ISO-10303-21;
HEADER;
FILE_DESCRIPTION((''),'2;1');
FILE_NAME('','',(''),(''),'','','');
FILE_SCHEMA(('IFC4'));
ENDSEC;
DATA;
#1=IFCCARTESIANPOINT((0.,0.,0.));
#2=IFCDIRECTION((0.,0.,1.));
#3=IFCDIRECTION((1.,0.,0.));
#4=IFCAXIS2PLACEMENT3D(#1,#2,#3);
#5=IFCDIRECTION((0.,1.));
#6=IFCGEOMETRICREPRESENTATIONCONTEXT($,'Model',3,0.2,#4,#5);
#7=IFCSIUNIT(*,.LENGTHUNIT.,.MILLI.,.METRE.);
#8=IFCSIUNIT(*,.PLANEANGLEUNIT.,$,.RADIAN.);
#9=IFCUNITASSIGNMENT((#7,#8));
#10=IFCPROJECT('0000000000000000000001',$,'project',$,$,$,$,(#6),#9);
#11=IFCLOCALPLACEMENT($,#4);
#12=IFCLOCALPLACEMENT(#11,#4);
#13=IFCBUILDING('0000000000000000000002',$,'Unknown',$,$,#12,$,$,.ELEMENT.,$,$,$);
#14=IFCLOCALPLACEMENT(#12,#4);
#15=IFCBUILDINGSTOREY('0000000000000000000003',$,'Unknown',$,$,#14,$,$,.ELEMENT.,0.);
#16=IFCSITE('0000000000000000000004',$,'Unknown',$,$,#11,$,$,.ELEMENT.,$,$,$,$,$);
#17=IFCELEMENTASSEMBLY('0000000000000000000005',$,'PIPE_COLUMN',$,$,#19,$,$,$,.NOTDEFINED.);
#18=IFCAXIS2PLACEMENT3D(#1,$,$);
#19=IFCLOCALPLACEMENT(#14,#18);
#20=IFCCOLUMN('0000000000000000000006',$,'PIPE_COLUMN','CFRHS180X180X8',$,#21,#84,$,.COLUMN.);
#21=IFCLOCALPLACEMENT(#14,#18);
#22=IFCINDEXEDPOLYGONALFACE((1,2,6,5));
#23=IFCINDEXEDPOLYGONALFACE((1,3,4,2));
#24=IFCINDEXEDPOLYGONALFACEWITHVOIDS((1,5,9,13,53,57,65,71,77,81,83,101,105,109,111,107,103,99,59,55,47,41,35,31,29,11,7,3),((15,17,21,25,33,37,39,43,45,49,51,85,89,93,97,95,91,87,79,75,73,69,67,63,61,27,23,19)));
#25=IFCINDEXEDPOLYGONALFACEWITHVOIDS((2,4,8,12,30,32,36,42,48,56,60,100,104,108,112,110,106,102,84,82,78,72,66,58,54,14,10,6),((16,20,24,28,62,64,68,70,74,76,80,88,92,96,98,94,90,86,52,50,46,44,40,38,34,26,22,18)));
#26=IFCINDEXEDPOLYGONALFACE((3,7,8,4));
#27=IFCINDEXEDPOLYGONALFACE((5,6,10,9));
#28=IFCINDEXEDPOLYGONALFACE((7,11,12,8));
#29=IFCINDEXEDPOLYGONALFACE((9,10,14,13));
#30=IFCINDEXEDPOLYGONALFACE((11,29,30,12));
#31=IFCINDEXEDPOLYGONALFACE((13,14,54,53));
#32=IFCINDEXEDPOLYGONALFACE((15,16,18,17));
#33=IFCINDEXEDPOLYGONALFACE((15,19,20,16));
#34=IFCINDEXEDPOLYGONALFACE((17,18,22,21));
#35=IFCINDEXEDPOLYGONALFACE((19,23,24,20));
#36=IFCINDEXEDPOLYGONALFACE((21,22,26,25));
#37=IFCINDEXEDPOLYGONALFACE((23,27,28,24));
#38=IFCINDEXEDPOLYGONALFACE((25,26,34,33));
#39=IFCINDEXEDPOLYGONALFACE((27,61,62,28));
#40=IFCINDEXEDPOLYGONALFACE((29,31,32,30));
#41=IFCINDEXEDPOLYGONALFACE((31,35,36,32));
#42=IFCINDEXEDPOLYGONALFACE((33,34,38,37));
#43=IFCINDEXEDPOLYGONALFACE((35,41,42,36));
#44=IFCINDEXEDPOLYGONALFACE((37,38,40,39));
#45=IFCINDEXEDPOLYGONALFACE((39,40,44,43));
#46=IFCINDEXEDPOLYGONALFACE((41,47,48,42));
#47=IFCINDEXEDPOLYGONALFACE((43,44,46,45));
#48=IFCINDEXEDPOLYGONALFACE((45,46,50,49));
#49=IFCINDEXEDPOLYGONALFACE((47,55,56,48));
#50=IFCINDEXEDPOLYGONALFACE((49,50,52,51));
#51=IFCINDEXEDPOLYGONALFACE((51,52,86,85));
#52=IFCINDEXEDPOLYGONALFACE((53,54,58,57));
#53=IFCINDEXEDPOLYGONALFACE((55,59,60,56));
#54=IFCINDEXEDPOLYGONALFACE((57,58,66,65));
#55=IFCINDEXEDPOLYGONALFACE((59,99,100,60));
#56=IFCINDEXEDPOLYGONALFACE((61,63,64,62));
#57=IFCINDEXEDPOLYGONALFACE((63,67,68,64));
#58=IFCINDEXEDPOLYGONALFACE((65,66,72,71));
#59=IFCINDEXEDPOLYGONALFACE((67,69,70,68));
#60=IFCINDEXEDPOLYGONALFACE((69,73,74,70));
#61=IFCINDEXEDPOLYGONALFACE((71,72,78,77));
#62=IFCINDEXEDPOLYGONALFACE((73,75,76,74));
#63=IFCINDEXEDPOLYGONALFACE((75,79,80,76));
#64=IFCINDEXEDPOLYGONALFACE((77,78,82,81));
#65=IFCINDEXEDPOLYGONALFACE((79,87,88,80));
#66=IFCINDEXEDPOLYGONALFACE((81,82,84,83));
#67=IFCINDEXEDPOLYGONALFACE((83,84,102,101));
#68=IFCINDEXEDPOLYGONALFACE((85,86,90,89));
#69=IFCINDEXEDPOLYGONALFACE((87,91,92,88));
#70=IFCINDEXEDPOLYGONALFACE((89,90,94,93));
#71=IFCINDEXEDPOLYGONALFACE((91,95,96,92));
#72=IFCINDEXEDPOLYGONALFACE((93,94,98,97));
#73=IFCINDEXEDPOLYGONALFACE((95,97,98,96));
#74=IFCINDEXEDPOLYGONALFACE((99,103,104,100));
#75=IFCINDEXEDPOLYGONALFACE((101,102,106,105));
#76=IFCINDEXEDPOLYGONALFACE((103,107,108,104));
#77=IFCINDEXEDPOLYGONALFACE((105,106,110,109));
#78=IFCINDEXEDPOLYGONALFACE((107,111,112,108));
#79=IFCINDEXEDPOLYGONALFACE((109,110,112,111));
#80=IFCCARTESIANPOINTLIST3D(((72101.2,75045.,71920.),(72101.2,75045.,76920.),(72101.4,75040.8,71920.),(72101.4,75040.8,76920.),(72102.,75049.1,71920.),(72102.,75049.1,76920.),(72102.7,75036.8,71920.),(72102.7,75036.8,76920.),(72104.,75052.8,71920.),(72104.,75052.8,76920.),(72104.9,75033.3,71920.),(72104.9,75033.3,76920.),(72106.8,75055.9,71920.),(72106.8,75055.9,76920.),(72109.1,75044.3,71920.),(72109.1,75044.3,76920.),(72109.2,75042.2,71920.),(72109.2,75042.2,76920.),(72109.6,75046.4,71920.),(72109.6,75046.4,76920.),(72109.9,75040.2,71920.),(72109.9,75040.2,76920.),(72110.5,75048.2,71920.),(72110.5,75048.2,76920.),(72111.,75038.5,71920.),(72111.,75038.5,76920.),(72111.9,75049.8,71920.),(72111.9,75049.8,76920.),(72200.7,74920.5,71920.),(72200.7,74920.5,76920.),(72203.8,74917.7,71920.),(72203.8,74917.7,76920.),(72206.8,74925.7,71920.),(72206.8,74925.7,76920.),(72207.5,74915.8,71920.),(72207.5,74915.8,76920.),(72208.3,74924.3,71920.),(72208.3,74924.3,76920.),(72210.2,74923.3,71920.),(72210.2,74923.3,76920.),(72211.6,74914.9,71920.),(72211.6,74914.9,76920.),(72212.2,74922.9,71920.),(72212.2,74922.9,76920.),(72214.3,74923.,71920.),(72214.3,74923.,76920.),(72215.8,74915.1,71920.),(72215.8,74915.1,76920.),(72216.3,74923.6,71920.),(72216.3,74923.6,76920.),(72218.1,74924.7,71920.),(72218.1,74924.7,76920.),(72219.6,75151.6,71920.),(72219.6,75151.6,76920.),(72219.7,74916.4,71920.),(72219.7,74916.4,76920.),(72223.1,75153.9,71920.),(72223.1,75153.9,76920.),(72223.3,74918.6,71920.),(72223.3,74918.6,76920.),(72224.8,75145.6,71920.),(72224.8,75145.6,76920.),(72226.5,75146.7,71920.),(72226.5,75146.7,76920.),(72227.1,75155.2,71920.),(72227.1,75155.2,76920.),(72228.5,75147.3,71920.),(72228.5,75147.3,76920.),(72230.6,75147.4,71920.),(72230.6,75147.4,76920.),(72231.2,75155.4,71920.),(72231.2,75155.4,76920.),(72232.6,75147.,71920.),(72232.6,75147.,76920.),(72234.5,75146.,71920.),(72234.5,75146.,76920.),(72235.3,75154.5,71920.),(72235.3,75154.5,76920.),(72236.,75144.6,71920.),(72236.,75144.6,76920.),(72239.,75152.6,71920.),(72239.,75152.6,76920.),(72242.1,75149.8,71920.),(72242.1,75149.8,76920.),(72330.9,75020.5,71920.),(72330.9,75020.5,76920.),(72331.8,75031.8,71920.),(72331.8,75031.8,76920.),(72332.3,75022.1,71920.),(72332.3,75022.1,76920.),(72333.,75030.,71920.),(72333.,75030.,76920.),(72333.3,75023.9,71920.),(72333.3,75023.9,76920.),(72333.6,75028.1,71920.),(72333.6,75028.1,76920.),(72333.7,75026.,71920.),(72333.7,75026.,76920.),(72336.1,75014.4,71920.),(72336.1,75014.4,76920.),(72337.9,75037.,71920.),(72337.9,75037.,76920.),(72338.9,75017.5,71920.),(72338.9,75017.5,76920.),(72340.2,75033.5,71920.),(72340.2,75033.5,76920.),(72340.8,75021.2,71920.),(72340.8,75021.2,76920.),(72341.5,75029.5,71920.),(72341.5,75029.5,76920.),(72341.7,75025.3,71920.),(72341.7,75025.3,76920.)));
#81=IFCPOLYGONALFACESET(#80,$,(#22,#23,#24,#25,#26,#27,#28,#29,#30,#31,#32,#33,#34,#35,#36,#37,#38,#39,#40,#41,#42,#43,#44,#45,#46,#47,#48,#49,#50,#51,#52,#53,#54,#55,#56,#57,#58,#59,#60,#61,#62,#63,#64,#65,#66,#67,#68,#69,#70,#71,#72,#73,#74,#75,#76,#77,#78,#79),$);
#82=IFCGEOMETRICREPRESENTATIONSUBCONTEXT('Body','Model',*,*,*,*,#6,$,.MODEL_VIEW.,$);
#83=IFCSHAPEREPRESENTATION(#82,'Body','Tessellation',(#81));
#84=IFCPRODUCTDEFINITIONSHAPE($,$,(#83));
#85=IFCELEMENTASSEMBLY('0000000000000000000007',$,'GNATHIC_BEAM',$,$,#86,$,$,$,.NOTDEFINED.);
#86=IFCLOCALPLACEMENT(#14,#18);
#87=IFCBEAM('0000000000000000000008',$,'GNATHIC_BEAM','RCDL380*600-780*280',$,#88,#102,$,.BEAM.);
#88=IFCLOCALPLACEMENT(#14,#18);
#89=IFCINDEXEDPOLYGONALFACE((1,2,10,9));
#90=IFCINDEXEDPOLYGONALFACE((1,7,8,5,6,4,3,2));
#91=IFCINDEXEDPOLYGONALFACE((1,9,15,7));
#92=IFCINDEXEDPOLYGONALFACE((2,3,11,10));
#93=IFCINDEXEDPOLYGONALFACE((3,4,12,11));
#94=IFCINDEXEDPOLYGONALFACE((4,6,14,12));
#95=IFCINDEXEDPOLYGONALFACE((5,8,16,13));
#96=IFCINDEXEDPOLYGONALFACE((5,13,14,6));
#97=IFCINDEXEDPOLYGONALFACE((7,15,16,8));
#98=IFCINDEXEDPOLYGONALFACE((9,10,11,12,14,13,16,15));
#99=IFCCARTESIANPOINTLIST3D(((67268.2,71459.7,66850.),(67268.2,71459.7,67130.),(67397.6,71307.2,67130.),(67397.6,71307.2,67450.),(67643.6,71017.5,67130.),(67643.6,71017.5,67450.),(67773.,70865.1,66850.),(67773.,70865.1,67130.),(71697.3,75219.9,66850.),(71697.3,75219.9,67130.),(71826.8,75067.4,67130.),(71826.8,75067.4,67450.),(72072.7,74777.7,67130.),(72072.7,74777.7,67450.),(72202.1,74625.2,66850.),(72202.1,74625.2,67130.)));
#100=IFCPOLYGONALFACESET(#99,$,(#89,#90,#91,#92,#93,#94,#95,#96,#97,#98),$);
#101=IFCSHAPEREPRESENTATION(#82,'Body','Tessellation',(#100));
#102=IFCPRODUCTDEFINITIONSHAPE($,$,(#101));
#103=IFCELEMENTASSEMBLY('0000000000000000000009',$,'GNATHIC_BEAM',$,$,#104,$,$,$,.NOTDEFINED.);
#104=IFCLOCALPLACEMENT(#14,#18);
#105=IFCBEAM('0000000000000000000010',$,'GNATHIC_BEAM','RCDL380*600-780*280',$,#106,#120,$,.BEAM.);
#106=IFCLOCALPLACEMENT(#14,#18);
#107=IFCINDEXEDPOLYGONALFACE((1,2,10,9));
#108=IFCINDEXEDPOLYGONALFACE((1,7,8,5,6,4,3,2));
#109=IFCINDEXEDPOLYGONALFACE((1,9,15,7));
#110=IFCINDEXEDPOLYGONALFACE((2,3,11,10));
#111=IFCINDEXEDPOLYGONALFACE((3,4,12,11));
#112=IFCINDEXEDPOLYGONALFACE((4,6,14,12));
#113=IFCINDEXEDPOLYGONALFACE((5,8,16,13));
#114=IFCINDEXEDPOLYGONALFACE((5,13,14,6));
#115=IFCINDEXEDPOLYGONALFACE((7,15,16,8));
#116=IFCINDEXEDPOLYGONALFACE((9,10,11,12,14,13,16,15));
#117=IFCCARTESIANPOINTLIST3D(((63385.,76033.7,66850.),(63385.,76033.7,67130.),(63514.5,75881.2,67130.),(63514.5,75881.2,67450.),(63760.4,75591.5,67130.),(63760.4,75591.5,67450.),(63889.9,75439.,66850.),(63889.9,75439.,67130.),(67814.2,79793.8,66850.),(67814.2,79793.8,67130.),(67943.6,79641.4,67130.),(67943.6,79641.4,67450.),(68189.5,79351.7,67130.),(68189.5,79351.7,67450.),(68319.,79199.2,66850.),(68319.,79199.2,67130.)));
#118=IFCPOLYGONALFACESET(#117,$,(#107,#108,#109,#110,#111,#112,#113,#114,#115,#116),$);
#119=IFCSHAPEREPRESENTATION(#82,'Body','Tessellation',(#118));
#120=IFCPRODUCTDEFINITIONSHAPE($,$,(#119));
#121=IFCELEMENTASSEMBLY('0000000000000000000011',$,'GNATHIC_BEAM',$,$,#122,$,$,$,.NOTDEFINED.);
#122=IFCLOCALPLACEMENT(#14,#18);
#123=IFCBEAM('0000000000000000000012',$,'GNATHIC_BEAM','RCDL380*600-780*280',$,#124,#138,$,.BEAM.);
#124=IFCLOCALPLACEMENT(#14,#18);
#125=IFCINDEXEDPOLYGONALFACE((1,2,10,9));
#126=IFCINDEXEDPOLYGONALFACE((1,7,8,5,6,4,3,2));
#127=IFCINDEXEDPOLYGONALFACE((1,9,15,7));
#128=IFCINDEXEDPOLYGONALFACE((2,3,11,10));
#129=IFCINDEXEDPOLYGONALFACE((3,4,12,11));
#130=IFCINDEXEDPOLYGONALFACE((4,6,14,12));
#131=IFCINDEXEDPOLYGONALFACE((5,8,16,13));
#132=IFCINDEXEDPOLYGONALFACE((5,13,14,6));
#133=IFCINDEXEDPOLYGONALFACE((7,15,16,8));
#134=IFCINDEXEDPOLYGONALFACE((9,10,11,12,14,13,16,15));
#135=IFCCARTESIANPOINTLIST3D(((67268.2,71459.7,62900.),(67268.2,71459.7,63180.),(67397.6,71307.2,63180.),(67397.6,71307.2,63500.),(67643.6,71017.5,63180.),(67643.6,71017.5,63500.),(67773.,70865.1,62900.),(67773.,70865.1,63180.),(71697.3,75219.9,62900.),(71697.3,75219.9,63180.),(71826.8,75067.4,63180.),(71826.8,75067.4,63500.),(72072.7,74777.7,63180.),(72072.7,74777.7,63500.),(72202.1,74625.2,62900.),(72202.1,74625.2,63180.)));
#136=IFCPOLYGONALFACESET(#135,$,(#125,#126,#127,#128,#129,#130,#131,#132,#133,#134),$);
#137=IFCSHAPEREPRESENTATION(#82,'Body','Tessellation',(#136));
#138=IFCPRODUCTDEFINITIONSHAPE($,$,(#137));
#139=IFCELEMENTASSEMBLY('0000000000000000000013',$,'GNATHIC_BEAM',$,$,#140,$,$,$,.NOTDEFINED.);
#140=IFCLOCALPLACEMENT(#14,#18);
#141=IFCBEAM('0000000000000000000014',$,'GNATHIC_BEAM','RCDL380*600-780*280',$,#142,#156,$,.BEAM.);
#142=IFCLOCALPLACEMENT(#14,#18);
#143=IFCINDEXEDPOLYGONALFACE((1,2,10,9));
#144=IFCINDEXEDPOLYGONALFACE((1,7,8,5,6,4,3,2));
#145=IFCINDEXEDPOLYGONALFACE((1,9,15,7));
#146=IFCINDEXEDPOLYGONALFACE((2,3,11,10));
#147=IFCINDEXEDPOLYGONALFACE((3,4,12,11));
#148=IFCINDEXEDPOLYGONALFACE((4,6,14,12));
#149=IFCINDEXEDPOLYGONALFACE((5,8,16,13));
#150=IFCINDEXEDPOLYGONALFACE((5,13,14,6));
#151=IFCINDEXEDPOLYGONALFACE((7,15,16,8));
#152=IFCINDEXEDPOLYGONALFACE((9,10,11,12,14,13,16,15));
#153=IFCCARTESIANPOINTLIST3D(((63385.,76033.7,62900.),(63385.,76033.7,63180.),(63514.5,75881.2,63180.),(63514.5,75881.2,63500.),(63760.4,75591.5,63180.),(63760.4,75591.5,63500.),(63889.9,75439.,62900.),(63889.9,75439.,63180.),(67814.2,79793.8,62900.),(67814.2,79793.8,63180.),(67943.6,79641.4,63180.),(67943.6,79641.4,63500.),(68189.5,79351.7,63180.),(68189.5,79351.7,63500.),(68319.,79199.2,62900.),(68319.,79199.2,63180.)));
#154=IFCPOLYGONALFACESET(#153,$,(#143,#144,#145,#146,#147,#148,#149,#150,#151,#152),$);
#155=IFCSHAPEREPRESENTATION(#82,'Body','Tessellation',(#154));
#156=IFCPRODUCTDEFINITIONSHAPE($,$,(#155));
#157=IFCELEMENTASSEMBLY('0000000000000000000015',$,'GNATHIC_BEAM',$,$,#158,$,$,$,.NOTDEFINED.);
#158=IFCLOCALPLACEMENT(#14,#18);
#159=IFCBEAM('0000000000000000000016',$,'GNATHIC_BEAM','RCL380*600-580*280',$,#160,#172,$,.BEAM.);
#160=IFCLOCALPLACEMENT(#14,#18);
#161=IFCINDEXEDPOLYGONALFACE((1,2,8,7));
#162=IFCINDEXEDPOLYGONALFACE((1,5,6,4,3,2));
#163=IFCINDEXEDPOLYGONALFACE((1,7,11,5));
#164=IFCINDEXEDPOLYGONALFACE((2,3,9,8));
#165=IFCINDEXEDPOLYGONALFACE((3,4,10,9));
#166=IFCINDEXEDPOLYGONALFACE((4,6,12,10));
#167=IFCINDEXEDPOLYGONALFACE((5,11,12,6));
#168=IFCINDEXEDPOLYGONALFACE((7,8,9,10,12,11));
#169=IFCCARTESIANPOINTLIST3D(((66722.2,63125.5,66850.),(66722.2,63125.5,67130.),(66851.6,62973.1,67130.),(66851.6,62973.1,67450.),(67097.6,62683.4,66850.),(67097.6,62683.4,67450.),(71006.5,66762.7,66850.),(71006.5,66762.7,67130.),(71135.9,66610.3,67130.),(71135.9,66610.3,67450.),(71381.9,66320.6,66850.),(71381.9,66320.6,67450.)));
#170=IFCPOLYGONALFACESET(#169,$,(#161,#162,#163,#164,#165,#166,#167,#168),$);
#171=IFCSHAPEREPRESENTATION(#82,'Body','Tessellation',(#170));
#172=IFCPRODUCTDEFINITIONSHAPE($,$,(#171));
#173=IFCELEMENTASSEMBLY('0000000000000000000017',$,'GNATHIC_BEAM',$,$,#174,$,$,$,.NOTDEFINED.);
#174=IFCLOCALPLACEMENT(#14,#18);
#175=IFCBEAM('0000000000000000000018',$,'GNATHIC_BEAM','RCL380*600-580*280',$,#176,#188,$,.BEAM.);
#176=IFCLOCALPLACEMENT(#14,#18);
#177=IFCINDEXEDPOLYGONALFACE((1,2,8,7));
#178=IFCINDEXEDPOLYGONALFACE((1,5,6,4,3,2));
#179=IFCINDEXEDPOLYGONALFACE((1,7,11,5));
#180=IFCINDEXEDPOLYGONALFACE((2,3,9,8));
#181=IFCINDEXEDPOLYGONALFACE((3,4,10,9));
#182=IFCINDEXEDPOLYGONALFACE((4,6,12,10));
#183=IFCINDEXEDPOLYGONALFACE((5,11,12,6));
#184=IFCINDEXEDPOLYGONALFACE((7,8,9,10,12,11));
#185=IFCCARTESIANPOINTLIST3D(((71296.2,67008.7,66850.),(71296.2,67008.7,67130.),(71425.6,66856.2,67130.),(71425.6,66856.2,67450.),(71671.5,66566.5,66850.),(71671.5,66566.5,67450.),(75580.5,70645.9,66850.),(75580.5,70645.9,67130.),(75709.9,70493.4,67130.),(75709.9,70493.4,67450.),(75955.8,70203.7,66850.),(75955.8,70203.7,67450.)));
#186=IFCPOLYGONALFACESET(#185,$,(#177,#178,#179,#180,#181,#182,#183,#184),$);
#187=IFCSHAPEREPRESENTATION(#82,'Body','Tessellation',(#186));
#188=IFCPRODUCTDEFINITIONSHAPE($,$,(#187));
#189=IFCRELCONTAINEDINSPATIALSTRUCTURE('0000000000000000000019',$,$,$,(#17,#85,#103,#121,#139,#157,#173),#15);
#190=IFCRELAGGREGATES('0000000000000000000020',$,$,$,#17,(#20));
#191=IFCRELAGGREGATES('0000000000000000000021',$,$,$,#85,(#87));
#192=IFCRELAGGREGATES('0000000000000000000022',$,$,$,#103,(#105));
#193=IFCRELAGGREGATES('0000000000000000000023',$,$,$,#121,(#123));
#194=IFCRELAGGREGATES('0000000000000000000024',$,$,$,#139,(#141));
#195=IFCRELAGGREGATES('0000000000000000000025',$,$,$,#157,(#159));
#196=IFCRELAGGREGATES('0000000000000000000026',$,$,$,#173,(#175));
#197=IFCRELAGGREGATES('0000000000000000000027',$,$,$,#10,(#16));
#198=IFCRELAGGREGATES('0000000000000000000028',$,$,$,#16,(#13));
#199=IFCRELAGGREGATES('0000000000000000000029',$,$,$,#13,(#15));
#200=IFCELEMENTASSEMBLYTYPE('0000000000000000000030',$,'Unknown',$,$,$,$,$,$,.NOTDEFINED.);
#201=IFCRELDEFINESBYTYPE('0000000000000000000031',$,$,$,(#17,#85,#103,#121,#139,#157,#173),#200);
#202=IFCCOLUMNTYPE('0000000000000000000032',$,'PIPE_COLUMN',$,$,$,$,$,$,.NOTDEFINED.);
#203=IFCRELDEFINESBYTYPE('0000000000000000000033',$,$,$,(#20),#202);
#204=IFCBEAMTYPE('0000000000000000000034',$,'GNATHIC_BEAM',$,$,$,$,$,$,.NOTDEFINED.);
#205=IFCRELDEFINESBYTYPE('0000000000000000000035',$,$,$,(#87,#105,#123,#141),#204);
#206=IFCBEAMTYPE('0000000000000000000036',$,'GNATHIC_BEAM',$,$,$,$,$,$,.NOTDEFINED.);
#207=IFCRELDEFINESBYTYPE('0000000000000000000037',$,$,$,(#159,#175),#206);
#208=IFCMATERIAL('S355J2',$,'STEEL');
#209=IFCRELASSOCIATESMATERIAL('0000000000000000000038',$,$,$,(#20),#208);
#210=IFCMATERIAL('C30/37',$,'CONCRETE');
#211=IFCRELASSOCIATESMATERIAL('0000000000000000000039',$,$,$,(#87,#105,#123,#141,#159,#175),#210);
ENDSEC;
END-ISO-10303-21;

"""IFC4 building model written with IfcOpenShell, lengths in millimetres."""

from ifc_helpers import new_model, si_unit, direction, frame, origin_with_axes, origin_2d_with_axis, place, context, subcontext, project, spatial, polyline, hollow_rectangle, outline, extrude, material, material_profile, profile_set, profile_usage, type_object, element, aggregate, save


model = new_model("IFC4")

# Units and contexts
model_context = context("Model", 3, precision=0.2, world=origin_with_axes(), true_north=direction((0.0, 1.0)))
body_context = subcontext(model_context, "Body", "Model", "MODEL_VIEW")
ifc_project = project(units=[si_unit("LENGTHUNIT", "METRE", prefix="MILLI"), si_unit("PLANEANGLEUNIT", "RADIAN")], contexts=[model_context])

# Site, building, storey
site_placement = place(None, origin_with_axes())
site = spatial("IfcSite", under=ifc_project, at=site_placement, Name="Unknown", CompositionType="ELEMENT")
building_placement = place(site_placement, origin_with_axes())
building = spatial("IfcBuilding", under=site, at=building_placement, Name="Unknown", CompositionType="ELEMENT")
storey_placement = place(building_placement, origin_with_axes())
storey = spatial("IfcBuildingStorey", under=building, at=storey_placement, Name="Unknown", CompositionType="ELEMENT", Elevation=0.0)

# Element assembly, column
element_assembly_type = type_object("IfcElementAssemblyType", Name="Unknown", PredefinedType="NOTDEFINED")
ifc_material_1 = material(Name="S355J2", Category="STEEL")
ifc_material_profile_1 = material_profile(ifc_material_1, hollow_rectangle(XDim=180.0, YDim=180.0, WallThickness=8.0, InnerFilletRadius=8.0, OuterFilletRadius=16.0, at=origin_2d_with_axis()), Name="CFRHS180X180X8")
ifc_profile_set_1 = profile_set([ifc_material_profile_1])
column_type_1 = type_object("IfcColumnType", Name="PIPE_COLUMN")
assembly_1_placement = place(storey_placement, frame((72221.4, 75035.1, 71920.0), z_axis=(-0.762329, -0.64719, 0.0), x_axis=(0.0, 0.0, 1.0)))
assembly_1 = element("IfcElementAssembly", 1, at=assembly_1_placement, inside=storey, type_object=element_assembly_type, Name="PIPE_COLUMN", PredefinedType="NOTDEFINED")
ifc_profile_usage_1 = profile_usage(ifc_profile_set_1, cardinal=7)
column_1_placement = place(assembly_1_placement, origin_with_axes())
column_1 = element("IfcColumn", 2, at=column_1_placement, type_object=column_type_1, material=ifc_profile_usage_1, Name="PIPE_COLUMN", Description="CFRHS180X180X8", PredefinedType="COLUMN", context=body_context, shape_type="SolidModel", body=[
    extrude(hollow_rectangle(XDim=180.0, YDim=180.0, WallThickness=8.0, InnerFilletRadius=8.0, OuterFilletRadius=16.0, at=origin_2d_with_axis()), frame((0.0, 0.0, 0.0), z_axis=(-1.0, 0.0, 0.0), x_axis=(0.0, 0.0, 1.0)), (0.0, 0.0, -1.0), 5000.0),
])
aggregate(assembly_1, [column_1])

# Element assemblies, beams
assembly_2_placement = place(storey_placement, frame((67520.6, 71162.4, 67150.0), z_axis=(0.64719, -0.762329, 0.0), x_axis=(0.762329, 0.64719, 0.0)))
assembly_2 = element("IfcElementAssembly", 3, at=assembly_2_placement, inside=storey, type_object=element_assembly_type, Name="GNATHIC_BEAM", PredefinedType="NOTDEFINED")
ifc_material_2 = material(Name="C30/37", Category="CONCRETE")
ifc_material_profile_2 = material_profile(ifc_material_2, outline(polyline([(-390.0, -300.0), (390.0, -300.0), (390.0, -20.0), (190.0, -20.0), (190.0, 300.0), (-190.0, 300.0), (-190.0, -20.0), (-390.0, -20.0), (-390.0, -300.0)])), Name="RCDL380*600-780*280")
ifc_profile_set_2 = profile_set([ifc_material_profile_2])
ifc_profile_usage_2 = profile_usage(ifc_profile_set_2, cardinal=2)
beam_type_1 = type_object("IfcBeamType", Name="GNATHIC_BEAM")
beam_1_placement = place(assembly_2_placement, origin_with_axes())
beam_1 = element("IfcBeam", 4, at=beam_1_placement, type_object=beam_type_1, material=ifc_profile_usage_2, Name="GNATHIC_BEAM", Description="RCDL380*600-780*280", PredefinedType="BEAM", context=body_context, shape_type="SolidModel", body=[
    extrude(outline(polyline([(-390.0, -300.0), (390.0, -300.0), (390.0, -20.0), (190.0, -20.0), (190.0, 300.0), (-190.0, 300.0), (-190.0, -20.0), (-390.0, -20.0), (-390.0, -300.0)])), frame((0.0, 0.0, 0.0), z_axis=(-1.0, 0.0, 0.0), x_axis=(0.0, 0.0, 1.0)), (0.0, 0.0, -1.0), 5810.0),
])
aggregate(assembly_2, [beam_1])
assembly_3_placement = place(storey_placement, frame((63637.4, 75736.3, 67150.0), z_axis=(0.64719, -0.762329, 0.0), x_axis=(0.762329, 0.64719, 0.0)))
assembly_3 = element("IfcElementAssembly", 5, at=assembly_3_placement, inside=storey, type_object=element_assembly_type, Name="GNATHIC_BEAM", PredefinedType="NOTDEFINED")
beam_2_placement = place(assembly_3_placement, origin_with_axes())
beam_2 = element("IfcBeam", 6, at=beam_2_placement, type_object=beam_type_1, material=ifc_profile_usage_2, Name="GNATHIC_BEAM", Description="RCDL380*600-780*280", PredefinedType="BEAM", context=body_context, shape_type="SolidModel", body=[
    extrude(outline(polyline([(-390.0, -300.0), (390.0, -300.0), (390.0, -20.0), (190.0, -20.0), (190.0, 300.0), (-190.0, 300.0), (-190.0, -20.0), (-390.0, -20.0), (-390.0, -300.0)])), frame((0.0, 0.0, 0.0), z_axis=(-1.0, 0.0, 0.0), x_axis=(0.0, 0.0, 1.0)), (0.0, 0.0, -1.0), 5810.0),
])
aggregate(assembly_3, [beam_2])
assembly_4_placement = place(storey_placement, frame((67520.6, 71162.4, 63200.0), z_axis=(0.64719, -0.762329, 0.0), x_axis=(0.762329, 0.64719, 0.0)))
assembly_4 = element("IfcElementAssembly", 7, at=assembly_4_placement, inside=storey, type_object=element_assembly_type, Name="GNATHIC_BEAM", PredefinedType="NOTDEFINED")
beam_3_placement = place(assembly_4_placement, origin_with_axes())
beam_3 = element("IfcBeam", 8, at=beam_3_placement, type_object=beam_type_1, material=ifc_profile_usage_2, Name="GNATHIC_BEAM", Description="RCDL380*600-780*280", PredefinedType="BEAM", context=body_context, shape_type="SolidModel", body=[
    extrude(outline(polyline([(-390.0, -300.0), (390.0, -300.0), (390.0, -20.0), (190.0, -20.0), (190.0, 300.0), (-190.0, 300.0), (-190.0, -20.0), (-390.0, -20.0), (-390.0, -300.0)])), frame((0.0, 0.0, 0.0), z_axis=(-1.0, 0.0, 0.0), x_axis=(0.0, 0.0, 1.0)), (0.0, 0.0, -1.0), 5810.0),
])
aggregate(assembly_4, [beam_3])
assembly_5_placement = place(storey_placement, frame((63637.4, 75736.3, 63200.0), z_axis=(0.64719, -0.762329, 0.0), x_axis=(0.762329, 0.64719, 0.0)))
assembly_5 = element("IfcElementAssembly", 9, at=assembly_5_placement, inside=storey, type_object=element_assembly_type, Name="GNATHIC_BEAM", PredefinedType="NOTDEFINED")
beam_4_placement = place(assembly_5_placement, origin_with_axes())
beam_4 = element("IfcBeam", 10, at=beam_4_placement, type_object=beam_type_1, material=ifc_profile_usage_2, Name="GNATHIC_BEAM", Description="RCDL380*600-780*280", PredefinedType="BEAM", context=body_context, shape_type="SolidModel", body=[
    extrude(outline(polyline([(-390.0, -300.0), (390.0, -300.0), (390.0, -20.0), (190.0, -20.0), (190.0, 300.0), (-190.0, 300.0), (-190.0, -20.0), (-390.0, -20.0), (-390.0, -300.0)])), frame((0.0, 0.0, 0.0), z_axis=(-1.0, 0.0, 0.0), x_axis=(0.0, 0.0, 1.0)), (0.0, 0.0, -1.0), 5810.0),
])
aggregate(assembly_5, [beam_4])
assembly_6_placement = place(storey_placement, frame((71258.9, 66465.4, 67150.0), z_axis=(-0.64719, 0.762329, 0.0), x_axis=(-0.762329, -0.64719, 0.0)))
assembly_6 = element("IfcElementAssembly", 11, at=assembly_6_placement, inside=storey, type_object=element_assembly_type, Name="GNATHIC_BEAM", PredefinedType="NOTDEFINED")
ifc_material_profile_3 = material_profile(ifc_material_2, outline(polyline([(-190.0, -300.0), (390.0, -300.0), (390.0, -20.0), (190.0, -20.0), (190.0, 300.0), (-190.0, 300.0), (-190.0, -300.0)])), Name="RCL380*600-580*280")
ifc_profile_set_3 = profile_set([ifc_material_profile_3])
ifc_profile_usage_3 = profile_usage(ifc_profile_set_3, cardinal=2)
beam_type_2 = type_object("IfcBeamType", Name="GNATHIC_BEAM")
beam_5_placement = place(assembly_6_placement, origin_with_axes())
beam_5 = element("IfcBeam", 12, at=beam_5_placement, type_object=beam_type_2, material=ifc_profile_usage_3, Name="GNATHIC_BEAM", Description="RCL380*600-580*280", PredefinedType="BEAM", context=body_context, shape_type="SolidModel", body=[
    extrude(outline(polyline([(-190.0, -300.0), (390.0, -300.0), (390.0, -20.0), (190.0, -20.0), (190.0, 300.0), (-190.0, 300.0), (-190.0, -300.0)])), frame((0.0, 0.0, 0.0), z_axis=(-1.0, 0.0, 0.0), x_axis=(0.0, 0.0, 1.0)), (0.0, 0.0, -1.0), 5620.0),
])
aggregate(assembly_6, [beam_5])
assembly_7_placement = place(storey_placement, frame((75832.9, 70348.6, 67150.0), z_axis=(-0.64719, 0.762329, 0.0), x_axis=(-0.762329, -0.64719, 0.0)))
assembly_7 = element("IfcElementAssembly", 13, at=assembly_7_placement, inside=storey, type_object=element_assembly_type, Name="GNATHIC_BEAM", PredefinedType="NOTDEFINED")
beam_6_placement = place(assembly_7_placement, origin_with_axes())
beam_6 = element("IfcBeam", 14, at=beam_6_placement, type_object=beam_type_2, material=ifc_profile_usage_3, Name="GNATHIC_BEAM", Description="RCL380*600-580*280", PredefinedType="BEAM", context=body_context, shape_type="SolidModel", body=[
    extrude(outline(polyline([(-190.0, -300.0), (390.0, -300.0), (390.0, -20.0), (190.0, -20.0), (190.0, 300.0), (-190.0, 300.0), (-190.0, -300.0)])), frame((0.0, 0.0, 0.0), z_axis=(-1.0, 0.0, 0.0), x_axis=(0.0, 0.0, 1.0)), (0.0, 0.0, -1.0), 5620.0),
])
aggregate(assembly_7, [beam_6])

save(model, "model.ifc")
